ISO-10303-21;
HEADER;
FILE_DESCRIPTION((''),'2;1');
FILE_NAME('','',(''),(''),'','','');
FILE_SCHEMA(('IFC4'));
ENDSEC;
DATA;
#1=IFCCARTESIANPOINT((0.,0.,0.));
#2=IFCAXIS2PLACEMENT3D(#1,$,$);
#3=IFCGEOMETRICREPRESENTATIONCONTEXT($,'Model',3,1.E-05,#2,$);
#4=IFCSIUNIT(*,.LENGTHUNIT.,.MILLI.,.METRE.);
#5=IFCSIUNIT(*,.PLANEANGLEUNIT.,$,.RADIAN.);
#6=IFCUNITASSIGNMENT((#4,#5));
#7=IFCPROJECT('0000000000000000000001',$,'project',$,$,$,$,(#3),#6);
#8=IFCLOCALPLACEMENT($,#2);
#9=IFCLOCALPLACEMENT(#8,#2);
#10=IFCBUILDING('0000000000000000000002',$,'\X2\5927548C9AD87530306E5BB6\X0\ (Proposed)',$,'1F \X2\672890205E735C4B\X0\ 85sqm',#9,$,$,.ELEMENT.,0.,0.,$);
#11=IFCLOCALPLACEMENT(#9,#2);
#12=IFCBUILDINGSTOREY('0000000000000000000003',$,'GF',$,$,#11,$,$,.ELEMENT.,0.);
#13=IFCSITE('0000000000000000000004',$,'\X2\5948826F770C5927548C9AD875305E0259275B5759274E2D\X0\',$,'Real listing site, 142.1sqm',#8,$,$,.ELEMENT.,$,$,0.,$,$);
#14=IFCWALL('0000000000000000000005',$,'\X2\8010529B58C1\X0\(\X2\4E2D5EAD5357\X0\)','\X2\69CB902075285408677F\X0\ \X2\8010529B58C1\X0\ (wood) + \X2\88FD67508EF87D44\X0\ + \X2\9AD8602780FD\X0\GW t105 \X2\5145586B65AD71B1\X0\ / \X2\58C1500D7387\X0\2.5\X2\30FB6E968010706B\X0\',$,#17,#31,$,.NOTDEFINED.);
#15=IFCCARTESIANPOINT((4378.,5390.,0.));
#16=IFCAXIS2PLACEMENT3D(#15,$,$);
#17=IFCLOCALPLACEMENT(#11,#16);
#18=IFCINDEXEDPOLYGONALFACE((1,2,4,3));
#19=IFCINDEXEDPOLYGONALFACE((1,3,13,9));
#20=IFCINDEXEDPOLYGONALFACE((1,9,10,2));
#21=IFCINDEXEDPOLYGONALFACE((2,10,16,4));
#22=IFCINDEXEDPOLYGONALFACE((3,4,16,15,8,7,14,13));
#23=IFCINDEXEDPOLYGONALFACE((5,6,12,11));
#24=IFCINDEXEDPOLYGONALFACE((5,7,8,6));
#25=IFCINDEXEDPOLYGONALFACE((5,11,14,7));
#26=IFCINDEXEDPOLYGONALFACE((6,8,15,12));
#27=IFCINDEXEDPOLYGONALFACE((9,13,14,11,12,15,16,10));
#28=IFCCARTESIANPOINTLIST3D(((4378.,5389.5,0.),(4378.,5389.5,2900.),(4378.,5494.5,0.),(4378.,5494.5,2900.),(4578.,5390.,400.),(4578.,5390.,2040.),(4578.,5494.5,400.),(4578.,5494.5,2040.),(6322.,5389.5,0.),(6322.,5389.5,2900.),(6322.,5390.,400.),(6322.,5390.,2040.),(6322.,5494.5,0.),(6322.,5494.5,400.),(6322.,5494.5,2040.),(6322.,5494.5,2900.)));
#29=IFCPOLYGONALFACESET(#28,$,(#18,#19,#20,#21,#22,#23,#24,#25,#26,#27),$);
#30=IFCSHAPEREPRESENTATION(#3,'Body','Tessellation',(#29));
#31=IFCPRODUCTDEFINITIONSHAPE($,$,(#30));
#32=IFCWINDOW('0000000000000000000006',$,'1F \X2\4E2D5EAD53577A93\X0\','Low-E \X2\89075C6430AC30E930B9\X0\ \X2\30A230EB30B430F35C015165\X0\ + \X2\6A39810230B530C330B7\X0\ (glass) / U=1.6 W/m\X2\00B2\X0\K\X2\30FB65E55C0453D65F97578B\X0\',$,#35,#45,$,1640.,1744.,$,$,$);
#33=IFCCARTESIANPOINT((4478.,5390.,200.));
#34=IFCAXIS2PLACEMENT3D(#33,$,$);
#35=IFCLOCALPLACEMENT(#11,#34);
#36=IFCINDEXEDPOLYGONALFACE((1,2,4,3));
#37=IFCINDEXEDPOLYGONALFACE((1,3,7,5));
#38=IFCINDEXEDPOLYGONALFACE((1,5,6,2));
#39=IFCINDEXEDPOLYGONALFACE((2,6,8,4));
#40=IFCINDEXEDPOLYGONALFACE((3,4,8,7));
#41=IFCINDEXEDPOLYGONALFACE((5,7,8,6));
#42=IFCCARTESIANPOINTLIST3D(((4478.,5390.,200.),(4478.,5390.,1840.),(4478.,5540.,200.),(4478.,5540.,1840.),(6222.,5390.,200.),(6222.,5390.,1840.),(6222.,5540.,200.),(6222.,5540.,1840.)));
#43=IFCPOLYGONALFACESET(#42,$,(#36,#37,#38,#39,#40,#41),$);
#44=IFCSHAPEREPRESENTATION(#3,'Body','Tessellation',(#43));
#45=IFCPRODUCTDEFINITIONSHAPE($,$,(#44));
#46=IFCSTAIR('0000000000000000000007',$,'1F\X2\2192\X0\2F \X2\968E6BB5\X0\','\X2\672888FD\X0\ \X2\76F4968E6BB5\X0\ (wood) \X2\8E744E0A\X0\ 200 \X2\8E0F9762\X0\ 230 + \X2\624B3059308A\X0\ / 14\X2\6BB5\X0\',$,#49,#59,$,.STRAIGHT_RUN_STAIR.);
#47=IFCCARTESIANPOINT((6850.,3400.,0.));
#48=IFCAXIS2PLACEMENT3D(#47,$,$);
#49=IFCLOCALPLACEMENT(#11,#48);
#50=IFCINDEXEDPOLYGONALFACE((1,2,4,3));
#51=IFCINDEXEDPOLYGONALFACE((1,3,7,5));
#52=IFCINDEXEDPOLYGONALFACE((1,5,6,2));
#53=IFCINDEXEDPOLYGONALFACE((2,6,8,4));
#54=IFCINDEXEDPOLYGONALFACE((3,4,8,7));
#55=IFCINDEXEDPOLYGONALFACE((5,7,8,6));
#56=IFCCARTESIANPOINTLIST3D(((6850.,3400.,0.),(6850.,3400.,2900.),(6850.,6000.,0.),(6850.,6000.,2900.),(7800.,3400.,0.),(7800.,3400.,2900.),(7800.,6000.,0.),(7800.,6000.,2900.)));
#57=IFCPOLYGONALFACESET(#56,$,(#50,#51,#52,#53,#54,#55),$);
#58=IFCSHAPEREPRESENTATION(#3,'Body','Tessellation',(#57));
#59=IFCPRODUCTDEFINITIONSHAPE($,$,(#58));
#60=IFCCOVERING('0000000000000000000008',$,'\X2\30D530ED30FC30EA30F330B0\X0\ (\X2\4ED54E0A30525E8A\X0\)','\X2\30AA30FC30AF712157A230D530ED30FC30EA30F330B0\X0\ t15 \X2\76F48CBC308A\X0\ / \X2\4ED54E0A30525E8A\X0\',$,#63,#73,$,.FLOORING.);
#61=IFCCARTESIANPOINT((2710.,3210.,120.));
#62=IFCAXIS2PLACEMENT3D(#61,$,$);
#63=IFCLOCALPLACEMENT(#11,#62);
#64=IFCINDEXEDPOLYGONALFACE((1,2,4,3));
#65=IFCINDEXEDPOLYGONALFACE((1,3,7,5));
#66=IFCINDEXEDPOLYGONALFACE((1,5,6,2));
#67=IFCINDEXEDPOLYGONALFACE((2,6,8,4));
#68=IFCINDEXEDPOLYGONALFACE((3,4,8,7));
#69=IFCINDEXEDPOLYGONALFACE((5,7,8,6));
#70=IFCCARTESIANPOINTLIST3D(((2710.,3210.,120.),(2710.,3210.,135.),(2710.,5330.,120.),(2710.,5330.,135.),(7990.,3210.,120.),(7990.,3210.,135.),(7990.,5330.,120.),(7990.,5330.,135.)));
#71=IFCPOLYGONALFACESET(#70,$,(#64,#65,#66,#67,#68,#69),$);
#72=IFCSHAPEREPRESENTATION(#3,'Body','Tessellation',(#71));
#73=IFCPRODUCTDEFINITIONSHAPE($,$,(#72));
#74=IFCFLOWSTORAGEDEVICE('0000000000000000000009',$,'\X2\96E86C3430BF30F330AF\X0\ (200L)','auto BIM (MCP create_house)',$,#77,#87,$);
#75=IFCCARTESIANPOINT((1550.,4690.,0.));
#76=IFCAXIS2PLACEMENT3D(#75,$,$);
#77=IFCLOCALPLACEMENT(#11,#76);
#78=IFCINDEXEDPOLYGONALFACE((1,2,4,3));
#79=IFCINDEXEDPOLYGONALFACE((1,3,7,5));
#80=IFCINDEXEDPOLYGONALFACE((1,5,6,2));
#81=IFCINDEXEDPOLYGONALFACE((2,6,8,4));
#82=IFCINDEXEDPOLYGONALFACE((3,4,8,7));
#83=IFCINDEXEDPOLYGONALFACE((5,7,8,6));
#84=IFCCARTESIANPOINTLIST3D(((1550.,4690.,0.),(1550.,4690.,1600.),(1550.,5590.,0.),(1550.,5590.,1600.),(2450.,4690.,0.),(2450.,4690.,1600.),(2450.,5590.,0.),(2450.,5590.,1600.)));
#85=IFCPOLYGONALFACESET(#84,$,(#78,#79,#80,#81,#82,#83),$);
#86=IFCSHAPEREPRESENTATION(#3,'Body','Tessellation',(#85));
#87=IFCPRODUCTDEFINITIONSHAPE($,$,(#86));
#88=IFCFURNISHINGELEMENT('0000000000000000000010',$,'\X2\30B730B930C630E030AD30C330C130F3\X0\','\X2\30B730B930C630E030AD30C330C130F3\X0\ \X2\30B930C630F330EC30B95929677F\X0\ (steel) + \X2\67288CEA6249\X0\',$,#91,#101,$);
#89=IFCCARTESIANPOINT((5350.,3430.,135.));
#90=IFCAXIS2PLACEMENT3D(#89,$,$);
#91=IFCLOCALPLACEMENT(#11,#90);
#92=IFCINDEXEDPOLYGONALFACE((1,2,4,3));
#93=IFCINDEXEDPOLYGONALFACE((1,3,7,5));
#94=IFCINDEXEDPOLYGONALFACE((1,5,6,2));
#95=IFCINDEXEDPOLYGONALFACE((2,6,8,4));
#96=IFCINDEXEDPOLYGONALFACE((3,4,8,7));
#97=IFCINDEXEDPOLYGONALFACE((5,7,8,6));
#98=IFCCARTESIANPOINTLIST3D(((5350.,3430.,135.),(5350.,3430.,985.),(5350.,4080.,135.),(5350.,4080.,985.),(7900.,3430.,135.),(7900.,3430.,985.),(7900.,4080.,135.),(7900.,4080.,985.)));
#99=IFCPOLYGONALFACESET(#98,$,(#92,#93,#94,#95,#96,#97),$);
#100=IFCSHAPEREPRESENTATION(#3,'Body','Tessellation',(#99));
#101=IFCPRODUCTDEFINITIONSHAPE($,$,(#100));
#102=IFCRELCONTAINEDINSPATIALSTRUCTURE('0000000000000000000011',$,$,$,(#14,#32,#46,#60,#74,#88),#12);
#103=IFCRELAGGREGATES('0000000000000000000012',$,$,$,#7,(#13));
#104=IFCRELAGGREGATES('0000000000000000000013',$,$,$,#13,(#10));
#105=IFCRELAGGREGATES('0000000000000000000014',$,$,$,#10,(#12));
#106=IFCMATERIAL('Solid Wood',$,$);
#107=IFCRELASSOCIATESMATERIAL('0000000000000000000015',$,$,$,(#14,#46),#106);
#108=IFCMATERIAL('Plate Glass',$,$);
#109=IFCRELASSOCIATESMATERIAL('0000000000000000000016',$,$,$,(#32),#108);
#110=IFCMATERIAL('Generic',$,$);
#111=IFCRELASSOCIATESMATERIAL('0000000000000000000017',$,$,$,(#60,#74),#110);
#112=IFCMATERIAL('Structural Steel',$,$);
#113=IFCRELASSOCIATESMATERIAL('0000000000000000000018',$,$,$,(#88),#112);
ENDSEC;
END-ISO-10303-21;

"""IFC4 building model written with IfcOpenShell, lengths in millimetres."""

from ifc_helpers import new_model, si_unit, frame, frame_2d, origin, place, context, project, spatial, rectangle, extrude, material, element, fill, save


model = new_model("IFC4")

# Units and contexts
model_context = context("Model", 3, precision=1e-05, world=origin())
ifc_project = project(units=[si_unit("LENGTHUNIT", "METRE", prefix="MILLI"), si_unit("PLANEANGLEUNIT", "RADIAN")], contexts=[model_context])

# Site, building, storey
site_placement = place(None, origin())
site = spatial("IfcSite", under=ifc_project, at=site_placement, Name="奈良県大和高田市大字大中", ObjectType="Real listing site, 142.1sqm", CompositionType="ELEMENT", RefElevation=0.0)
building_placement = place(site_placement, origin())
building = spatial("IfcBuilding", under=site, at=building_placement, Name="大和高田の家 (Proposed)", ObjectType="1F 木造平屋 85sqm", CompositionType="ELEMENT", ElevationOfRefHeight=0.0, ElevationOfTerrain=0.0)
storey_placement = place(building_placement, origin())
storey = spatial("IfcBuildingStorey", under=building, at=storey_placement, Name="GF", CompositionType="ELEMENT", Elevation=0.0)

# Shared definitions
ifc_material_1 = material(Name="Solid Wood")
ifc_material_2 = material(Name="Generic")

# Shared definitions
ifc_material_3 = material(Name="Plate Glass")

# Wall, opening, window
wall_1_placement = place(storey_placement, frame((4378.0, 5390.0, 0.0)))
wall_1 = element("IfcWall", 1, at=wall_1_placement, inside=storey, material=ifc_material_1, Name="耐力壁(中庭南)", Description="構造用合板 耐力壁 (wood) + 製材軸組 + 高性能GW t105 充填断熱 / 壁倍率2.5・準耐火", PredefinedType="NOTDEFINED", context=model_context, shape_type="SweptSolid", body=[
    extrude(rectangle(XDim=1944.0, YDim=105.0, at=frame_2d((972.0, 52.0))), frame((4378.0, 5390.0, 0.0)), (0.0, 0.0, 1.0), 2900.0),
])
opening_1_placement = place(storey_placement, frame((4478.0, 5390.0, 200.0)))
opening_1 = element("IfcOpeningElement", 2, at=opening_1_placement, cuts=wall_1, PredefinedType="NOTDEFINED", context=model_context, shape_type="SweptSolid", body=[
    extrude(rectangle(XDim=1744.0, YDim=150.0, at=frame_2d((872.0, 75.0))), frame((4478.0, 5390.0, 200.0)), (0.0, 0.0, 1.0), 1640.0),
])
window_1_placement = place(storey_placement, frame((4478.0, 5390.0, 200.0)))
window_1 = element("IfcWindow", 3, at=window_1_placement, inside=storey, material=ifc_material_3, Name="1F 中庭南窓", Description="Low-E 複層ガラス アルゴン封入 + 樹脂サッシ (glass) / U=1.6 W/m²K・日射取得型", OverallHeight=1640.0, OverallWidth=1744.0, context=model_context, shape_type="SweptSolid", body=[
    extrude(rectangle(XDim=1744.0, YDim=150.0, at=frame_2d((872.0, 75.0))), frame((4478.0, 5390.0, 200.0)), (0.0, 0.0, 1.0), 1640.0),
])
fill(opening_1, window_1)

# Stair
stair_placement = place(storey_placement, frame((6850.0, 3400.0, 0.0)))
element("IfcStair", 4, at=stair_placement, inside=storey, material=ifc_material_1, Name="1F→2F 階段", Description="木製 直階段 (wood) 蹴上 200 踏面 230 + 手すり / 14段", PredefinedType="STRAIGHT_RUN_STAIR", context=model_context, shape_type="SweptSolid", body=[
    extrude(rectangle(XDim=950.0, YDim=2600.0, at=frame_2d((475.0, 1300.0))), frame((6850.0, 3400.0, 0.0)), (0.0, 0.0, 1.0), 2900.0),
])

# Covering
covering_placement = place(storey_placement, frame((2710.0, 3210.0, 120.0)))
element("IfcCovering", 5, at=covering_placement, inside=storey, material=ifc_material_2, Name="フローリング (仕上げ床)", Description="オーク無垢フローリング t15 直貼り / 仕上げ床", PredefinedType="FLOORING", context=model_context, shape_type="SweptSolid", body=[
    extrude(rectangle(XDim=5280.0, YDim=2120.0, at=frame_2d((2640.0, 1060.0))), frame((2710.0, 3210.0, 120.0)), (0.0, 0.0, 1.0), 15.0),
])

# Flow storage device
flow_storage_device_placement = place(storey_placement, frame((1550.0, 4690.0, 0.0)))
element("IfcFlowStorageDevice", 6, at=flow_storage_device_placement, inside=storey, material=ifc_material_2, Name="雨水タンク (200L)", Description="auto BIM (MCP create_house)", context=model_context, shape_type="SweptSolid", body=[
    extrude(rectangle(XDim=900.0, YDim=900.0, at=frame_2d((450.0, 450.0))), frame((1550.0, 4690.0, 0.0)), (0.0, 0.0, 1.0), 1600.0),
])

# Furnishing element
ifc_material_4 = material(Name="Structural Steel")
furnishing_placement = place(storey_placement, frame((5350.0, 3430.0, 135.0)))
element("IfcFurnishingElement", 7, at=furnishing_placement, inside=storey, material=ifc_material_4, Name="システムキッチン", Description="システムキッチン ステンレス天板 (steel) + 木質扉", context=model_context, shape_type="SweptSolid", body=[
    extrude(rectangle(XDim=2550.0, YDim=650.0, at=frame_2d((1275.0, 325.0))), frame((5350.0, 3430.0, 135.0)), (0.0, 0.0, 1.0), 850.0),
])

save(model, "model.ifc")
